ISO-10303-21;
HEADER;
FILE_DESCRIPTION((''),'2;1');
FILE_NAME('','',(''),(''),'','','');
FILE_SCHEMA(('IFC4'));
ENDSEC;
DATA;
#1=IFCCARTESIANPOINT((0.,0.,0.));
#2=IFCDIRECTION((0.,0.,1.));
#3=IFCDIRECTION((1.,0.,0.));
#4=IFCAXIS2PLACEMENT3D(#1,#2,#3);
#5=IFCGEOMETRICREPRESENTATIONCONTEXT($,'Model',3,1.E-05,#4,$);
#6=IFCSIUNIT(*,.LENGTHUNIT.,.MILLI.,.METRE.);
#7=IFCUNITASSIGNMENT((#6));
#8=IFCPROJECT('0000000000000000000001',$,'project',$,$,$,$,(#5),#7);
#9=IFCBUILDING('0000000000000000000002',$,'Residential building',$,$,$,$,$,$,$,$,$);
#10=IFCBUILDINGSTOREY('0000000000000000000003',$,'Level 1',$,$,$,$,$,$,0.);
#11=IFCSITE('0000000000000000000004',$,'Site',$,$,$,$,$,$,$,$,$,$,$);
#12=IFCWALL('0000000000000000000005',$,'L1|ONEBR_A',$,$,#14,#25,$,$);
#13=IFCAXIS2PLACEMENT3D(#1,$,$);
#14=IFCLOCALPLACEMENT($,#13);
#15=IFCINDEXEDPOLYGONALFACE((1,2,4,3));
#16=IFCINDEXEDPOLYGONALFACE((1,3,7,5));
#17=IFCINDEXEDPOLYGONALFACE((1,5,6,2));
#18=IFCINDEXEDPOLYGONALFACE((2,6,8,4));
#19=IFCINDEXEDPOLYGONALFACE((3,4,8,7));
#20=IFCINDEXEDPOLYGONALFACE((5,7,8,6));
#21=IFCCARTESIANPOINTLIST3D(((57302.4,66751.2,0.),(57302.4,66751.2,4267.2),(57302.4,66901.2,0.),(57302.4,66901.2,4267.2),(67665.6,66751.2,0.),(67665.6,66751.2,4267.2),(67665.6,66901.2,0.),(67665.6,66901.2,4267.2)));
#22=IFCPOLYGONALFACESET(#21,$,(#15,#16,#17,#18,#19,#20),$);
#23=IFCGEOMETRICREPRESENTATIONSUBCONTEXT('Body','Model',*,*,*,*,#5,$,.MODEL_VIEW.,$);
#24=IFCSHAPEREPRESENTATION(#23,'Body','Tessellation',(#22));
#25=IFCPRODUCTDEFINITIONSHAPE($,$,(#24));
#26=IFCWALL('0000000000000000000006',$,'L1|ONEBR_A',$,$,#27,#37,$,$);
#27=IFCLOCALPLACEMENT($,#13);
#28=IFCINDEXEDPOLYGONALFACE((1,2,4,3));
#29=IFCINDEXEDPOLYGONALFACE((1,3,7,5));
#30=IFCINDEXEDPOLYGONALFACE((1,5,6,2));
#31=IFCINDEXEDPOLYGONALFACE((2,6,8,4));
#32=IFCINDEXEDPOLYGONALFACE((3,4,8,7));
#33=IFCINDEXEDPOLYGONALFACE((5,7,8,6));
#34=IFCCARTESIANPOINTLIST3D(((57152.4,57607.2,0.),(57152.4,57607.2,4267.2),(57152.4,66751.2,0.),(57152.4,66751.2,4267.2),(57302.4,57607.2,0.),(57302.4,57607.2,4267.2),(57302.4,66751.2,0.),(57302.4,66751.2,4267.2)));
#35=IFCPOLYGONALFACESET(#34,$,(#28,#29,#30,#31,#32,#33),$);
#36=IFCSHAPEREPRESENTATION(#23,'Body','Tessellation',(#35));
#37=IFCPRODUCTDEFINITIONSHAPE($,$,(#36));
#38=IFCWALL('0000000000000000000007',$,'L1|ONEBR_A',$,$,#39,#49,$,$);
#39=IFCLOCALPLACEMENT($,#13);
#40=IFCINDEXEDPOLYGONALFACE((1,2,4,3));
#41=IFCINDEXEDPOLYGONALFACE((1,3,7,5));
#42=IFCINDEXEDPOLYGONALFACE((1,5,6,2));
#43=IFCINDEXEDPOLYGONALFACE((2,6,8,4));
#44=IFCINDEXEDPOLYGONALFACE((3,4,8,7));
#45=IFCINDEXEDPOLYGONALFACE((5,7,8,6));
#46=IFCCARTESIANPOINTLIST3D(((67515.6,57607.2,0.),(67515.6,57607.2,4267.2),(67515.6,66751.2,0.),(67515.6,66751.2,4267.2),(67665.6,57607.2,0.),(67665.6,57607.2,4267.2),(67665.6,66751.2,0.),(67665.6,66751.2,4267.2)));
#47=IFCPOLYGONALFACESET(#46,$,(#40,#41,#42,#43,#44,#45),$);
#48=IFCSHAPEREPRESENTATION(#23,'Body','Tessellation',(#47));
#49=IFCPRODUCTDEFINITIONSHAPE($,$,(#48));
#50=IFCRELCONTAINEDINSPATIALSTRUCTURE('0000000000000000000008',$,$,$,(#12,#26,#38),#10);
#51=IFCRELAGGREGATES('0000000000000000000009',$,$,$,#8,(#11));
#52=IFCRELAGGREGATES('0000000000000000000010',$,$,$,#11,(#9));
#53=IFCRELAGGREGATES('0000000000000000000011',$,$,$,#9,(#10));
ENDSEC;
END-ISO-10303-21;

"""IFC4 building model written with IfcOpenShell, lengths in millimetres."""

from ifc_helpers import new_model, si_unit, frame, origin_with_axes, place, context, subcontext, project, spatial, indexed_curve, outline, extrude, element, save


model = new_model("IFC4")

# Units and contexts
model_context = context("Model", 3, precision=1e-05, world=origin_with_axes())
body_context = subcontext(model_context, "Body", "Model", "MODEL_VIEW")
ifc_project = project(units=[si_unit("LENGTHUNIT", "METRE", prefix="MILLI")], contexts=[model_context])

# Site, building, storey
site = spatial("IfcSite", under=ifc_project, Name="Site")
building = spatial("IfcBuilding", under=site, Name="Residential building")
storey = spatial("IfcBuildingStorey", under=building, Name="Level 1", Elevation=0.0)

# Walls
for number, where, z_axis, x_axis, name in (
    (1, (57302.4, 66751.2, 0.0), (0.0, 0.0, 1.0), (1.0, 0.0, 0.0), "L1|ONEBR_A"),
):
    element("IfcWall", number, at=place(None, frame(where, z_axis=z_axis, x_axis=x_axis)), inside=storey, Name=name, context=body_context, shape_type="SweptSolid", body=[
        extrude(outline(indexed_curve([(0.0, 0.0), (0.0, 150.0), (10363.2, 150.0), (10363.2, 0.0), (0.0, 0.0)], self_intersect=False)), origin_with_axes(), (0.0, 0.0, 1.0), 4267.2),
    ])
for number, where, z_axis, x_axis, name in (
    (2, (57302.4, 57607.2, 0.0), (0.0, 0.0, 1.0), (0.0, 1.0, 0.0), "L1|ONEBR_A"),
    (3, (67665.6, 57607.2, 0.0), (0.0, 0.0, 1.0), (0.0, 1.0, 0.0), "L1|ONEBR_A"),
):
    element("IfcWall", number, at=place(None, frame(where, z_axis=z_axis, x_axis=x_axis)), inside=storey, Name=name, context=body_context, shape_type="SweptSolid", body=[
        extrude(outline(indexed_curve([(0.0, 0.0), (0.0, 150.0), (9144.0, 150.0), (9144.0, 0.0), (0.0, 0.0)], self_intersect=False)), origin_with_axes(), (0.0, 0.0, 1.0), 4267.2),
    ])

save(model, "model.ifc")
